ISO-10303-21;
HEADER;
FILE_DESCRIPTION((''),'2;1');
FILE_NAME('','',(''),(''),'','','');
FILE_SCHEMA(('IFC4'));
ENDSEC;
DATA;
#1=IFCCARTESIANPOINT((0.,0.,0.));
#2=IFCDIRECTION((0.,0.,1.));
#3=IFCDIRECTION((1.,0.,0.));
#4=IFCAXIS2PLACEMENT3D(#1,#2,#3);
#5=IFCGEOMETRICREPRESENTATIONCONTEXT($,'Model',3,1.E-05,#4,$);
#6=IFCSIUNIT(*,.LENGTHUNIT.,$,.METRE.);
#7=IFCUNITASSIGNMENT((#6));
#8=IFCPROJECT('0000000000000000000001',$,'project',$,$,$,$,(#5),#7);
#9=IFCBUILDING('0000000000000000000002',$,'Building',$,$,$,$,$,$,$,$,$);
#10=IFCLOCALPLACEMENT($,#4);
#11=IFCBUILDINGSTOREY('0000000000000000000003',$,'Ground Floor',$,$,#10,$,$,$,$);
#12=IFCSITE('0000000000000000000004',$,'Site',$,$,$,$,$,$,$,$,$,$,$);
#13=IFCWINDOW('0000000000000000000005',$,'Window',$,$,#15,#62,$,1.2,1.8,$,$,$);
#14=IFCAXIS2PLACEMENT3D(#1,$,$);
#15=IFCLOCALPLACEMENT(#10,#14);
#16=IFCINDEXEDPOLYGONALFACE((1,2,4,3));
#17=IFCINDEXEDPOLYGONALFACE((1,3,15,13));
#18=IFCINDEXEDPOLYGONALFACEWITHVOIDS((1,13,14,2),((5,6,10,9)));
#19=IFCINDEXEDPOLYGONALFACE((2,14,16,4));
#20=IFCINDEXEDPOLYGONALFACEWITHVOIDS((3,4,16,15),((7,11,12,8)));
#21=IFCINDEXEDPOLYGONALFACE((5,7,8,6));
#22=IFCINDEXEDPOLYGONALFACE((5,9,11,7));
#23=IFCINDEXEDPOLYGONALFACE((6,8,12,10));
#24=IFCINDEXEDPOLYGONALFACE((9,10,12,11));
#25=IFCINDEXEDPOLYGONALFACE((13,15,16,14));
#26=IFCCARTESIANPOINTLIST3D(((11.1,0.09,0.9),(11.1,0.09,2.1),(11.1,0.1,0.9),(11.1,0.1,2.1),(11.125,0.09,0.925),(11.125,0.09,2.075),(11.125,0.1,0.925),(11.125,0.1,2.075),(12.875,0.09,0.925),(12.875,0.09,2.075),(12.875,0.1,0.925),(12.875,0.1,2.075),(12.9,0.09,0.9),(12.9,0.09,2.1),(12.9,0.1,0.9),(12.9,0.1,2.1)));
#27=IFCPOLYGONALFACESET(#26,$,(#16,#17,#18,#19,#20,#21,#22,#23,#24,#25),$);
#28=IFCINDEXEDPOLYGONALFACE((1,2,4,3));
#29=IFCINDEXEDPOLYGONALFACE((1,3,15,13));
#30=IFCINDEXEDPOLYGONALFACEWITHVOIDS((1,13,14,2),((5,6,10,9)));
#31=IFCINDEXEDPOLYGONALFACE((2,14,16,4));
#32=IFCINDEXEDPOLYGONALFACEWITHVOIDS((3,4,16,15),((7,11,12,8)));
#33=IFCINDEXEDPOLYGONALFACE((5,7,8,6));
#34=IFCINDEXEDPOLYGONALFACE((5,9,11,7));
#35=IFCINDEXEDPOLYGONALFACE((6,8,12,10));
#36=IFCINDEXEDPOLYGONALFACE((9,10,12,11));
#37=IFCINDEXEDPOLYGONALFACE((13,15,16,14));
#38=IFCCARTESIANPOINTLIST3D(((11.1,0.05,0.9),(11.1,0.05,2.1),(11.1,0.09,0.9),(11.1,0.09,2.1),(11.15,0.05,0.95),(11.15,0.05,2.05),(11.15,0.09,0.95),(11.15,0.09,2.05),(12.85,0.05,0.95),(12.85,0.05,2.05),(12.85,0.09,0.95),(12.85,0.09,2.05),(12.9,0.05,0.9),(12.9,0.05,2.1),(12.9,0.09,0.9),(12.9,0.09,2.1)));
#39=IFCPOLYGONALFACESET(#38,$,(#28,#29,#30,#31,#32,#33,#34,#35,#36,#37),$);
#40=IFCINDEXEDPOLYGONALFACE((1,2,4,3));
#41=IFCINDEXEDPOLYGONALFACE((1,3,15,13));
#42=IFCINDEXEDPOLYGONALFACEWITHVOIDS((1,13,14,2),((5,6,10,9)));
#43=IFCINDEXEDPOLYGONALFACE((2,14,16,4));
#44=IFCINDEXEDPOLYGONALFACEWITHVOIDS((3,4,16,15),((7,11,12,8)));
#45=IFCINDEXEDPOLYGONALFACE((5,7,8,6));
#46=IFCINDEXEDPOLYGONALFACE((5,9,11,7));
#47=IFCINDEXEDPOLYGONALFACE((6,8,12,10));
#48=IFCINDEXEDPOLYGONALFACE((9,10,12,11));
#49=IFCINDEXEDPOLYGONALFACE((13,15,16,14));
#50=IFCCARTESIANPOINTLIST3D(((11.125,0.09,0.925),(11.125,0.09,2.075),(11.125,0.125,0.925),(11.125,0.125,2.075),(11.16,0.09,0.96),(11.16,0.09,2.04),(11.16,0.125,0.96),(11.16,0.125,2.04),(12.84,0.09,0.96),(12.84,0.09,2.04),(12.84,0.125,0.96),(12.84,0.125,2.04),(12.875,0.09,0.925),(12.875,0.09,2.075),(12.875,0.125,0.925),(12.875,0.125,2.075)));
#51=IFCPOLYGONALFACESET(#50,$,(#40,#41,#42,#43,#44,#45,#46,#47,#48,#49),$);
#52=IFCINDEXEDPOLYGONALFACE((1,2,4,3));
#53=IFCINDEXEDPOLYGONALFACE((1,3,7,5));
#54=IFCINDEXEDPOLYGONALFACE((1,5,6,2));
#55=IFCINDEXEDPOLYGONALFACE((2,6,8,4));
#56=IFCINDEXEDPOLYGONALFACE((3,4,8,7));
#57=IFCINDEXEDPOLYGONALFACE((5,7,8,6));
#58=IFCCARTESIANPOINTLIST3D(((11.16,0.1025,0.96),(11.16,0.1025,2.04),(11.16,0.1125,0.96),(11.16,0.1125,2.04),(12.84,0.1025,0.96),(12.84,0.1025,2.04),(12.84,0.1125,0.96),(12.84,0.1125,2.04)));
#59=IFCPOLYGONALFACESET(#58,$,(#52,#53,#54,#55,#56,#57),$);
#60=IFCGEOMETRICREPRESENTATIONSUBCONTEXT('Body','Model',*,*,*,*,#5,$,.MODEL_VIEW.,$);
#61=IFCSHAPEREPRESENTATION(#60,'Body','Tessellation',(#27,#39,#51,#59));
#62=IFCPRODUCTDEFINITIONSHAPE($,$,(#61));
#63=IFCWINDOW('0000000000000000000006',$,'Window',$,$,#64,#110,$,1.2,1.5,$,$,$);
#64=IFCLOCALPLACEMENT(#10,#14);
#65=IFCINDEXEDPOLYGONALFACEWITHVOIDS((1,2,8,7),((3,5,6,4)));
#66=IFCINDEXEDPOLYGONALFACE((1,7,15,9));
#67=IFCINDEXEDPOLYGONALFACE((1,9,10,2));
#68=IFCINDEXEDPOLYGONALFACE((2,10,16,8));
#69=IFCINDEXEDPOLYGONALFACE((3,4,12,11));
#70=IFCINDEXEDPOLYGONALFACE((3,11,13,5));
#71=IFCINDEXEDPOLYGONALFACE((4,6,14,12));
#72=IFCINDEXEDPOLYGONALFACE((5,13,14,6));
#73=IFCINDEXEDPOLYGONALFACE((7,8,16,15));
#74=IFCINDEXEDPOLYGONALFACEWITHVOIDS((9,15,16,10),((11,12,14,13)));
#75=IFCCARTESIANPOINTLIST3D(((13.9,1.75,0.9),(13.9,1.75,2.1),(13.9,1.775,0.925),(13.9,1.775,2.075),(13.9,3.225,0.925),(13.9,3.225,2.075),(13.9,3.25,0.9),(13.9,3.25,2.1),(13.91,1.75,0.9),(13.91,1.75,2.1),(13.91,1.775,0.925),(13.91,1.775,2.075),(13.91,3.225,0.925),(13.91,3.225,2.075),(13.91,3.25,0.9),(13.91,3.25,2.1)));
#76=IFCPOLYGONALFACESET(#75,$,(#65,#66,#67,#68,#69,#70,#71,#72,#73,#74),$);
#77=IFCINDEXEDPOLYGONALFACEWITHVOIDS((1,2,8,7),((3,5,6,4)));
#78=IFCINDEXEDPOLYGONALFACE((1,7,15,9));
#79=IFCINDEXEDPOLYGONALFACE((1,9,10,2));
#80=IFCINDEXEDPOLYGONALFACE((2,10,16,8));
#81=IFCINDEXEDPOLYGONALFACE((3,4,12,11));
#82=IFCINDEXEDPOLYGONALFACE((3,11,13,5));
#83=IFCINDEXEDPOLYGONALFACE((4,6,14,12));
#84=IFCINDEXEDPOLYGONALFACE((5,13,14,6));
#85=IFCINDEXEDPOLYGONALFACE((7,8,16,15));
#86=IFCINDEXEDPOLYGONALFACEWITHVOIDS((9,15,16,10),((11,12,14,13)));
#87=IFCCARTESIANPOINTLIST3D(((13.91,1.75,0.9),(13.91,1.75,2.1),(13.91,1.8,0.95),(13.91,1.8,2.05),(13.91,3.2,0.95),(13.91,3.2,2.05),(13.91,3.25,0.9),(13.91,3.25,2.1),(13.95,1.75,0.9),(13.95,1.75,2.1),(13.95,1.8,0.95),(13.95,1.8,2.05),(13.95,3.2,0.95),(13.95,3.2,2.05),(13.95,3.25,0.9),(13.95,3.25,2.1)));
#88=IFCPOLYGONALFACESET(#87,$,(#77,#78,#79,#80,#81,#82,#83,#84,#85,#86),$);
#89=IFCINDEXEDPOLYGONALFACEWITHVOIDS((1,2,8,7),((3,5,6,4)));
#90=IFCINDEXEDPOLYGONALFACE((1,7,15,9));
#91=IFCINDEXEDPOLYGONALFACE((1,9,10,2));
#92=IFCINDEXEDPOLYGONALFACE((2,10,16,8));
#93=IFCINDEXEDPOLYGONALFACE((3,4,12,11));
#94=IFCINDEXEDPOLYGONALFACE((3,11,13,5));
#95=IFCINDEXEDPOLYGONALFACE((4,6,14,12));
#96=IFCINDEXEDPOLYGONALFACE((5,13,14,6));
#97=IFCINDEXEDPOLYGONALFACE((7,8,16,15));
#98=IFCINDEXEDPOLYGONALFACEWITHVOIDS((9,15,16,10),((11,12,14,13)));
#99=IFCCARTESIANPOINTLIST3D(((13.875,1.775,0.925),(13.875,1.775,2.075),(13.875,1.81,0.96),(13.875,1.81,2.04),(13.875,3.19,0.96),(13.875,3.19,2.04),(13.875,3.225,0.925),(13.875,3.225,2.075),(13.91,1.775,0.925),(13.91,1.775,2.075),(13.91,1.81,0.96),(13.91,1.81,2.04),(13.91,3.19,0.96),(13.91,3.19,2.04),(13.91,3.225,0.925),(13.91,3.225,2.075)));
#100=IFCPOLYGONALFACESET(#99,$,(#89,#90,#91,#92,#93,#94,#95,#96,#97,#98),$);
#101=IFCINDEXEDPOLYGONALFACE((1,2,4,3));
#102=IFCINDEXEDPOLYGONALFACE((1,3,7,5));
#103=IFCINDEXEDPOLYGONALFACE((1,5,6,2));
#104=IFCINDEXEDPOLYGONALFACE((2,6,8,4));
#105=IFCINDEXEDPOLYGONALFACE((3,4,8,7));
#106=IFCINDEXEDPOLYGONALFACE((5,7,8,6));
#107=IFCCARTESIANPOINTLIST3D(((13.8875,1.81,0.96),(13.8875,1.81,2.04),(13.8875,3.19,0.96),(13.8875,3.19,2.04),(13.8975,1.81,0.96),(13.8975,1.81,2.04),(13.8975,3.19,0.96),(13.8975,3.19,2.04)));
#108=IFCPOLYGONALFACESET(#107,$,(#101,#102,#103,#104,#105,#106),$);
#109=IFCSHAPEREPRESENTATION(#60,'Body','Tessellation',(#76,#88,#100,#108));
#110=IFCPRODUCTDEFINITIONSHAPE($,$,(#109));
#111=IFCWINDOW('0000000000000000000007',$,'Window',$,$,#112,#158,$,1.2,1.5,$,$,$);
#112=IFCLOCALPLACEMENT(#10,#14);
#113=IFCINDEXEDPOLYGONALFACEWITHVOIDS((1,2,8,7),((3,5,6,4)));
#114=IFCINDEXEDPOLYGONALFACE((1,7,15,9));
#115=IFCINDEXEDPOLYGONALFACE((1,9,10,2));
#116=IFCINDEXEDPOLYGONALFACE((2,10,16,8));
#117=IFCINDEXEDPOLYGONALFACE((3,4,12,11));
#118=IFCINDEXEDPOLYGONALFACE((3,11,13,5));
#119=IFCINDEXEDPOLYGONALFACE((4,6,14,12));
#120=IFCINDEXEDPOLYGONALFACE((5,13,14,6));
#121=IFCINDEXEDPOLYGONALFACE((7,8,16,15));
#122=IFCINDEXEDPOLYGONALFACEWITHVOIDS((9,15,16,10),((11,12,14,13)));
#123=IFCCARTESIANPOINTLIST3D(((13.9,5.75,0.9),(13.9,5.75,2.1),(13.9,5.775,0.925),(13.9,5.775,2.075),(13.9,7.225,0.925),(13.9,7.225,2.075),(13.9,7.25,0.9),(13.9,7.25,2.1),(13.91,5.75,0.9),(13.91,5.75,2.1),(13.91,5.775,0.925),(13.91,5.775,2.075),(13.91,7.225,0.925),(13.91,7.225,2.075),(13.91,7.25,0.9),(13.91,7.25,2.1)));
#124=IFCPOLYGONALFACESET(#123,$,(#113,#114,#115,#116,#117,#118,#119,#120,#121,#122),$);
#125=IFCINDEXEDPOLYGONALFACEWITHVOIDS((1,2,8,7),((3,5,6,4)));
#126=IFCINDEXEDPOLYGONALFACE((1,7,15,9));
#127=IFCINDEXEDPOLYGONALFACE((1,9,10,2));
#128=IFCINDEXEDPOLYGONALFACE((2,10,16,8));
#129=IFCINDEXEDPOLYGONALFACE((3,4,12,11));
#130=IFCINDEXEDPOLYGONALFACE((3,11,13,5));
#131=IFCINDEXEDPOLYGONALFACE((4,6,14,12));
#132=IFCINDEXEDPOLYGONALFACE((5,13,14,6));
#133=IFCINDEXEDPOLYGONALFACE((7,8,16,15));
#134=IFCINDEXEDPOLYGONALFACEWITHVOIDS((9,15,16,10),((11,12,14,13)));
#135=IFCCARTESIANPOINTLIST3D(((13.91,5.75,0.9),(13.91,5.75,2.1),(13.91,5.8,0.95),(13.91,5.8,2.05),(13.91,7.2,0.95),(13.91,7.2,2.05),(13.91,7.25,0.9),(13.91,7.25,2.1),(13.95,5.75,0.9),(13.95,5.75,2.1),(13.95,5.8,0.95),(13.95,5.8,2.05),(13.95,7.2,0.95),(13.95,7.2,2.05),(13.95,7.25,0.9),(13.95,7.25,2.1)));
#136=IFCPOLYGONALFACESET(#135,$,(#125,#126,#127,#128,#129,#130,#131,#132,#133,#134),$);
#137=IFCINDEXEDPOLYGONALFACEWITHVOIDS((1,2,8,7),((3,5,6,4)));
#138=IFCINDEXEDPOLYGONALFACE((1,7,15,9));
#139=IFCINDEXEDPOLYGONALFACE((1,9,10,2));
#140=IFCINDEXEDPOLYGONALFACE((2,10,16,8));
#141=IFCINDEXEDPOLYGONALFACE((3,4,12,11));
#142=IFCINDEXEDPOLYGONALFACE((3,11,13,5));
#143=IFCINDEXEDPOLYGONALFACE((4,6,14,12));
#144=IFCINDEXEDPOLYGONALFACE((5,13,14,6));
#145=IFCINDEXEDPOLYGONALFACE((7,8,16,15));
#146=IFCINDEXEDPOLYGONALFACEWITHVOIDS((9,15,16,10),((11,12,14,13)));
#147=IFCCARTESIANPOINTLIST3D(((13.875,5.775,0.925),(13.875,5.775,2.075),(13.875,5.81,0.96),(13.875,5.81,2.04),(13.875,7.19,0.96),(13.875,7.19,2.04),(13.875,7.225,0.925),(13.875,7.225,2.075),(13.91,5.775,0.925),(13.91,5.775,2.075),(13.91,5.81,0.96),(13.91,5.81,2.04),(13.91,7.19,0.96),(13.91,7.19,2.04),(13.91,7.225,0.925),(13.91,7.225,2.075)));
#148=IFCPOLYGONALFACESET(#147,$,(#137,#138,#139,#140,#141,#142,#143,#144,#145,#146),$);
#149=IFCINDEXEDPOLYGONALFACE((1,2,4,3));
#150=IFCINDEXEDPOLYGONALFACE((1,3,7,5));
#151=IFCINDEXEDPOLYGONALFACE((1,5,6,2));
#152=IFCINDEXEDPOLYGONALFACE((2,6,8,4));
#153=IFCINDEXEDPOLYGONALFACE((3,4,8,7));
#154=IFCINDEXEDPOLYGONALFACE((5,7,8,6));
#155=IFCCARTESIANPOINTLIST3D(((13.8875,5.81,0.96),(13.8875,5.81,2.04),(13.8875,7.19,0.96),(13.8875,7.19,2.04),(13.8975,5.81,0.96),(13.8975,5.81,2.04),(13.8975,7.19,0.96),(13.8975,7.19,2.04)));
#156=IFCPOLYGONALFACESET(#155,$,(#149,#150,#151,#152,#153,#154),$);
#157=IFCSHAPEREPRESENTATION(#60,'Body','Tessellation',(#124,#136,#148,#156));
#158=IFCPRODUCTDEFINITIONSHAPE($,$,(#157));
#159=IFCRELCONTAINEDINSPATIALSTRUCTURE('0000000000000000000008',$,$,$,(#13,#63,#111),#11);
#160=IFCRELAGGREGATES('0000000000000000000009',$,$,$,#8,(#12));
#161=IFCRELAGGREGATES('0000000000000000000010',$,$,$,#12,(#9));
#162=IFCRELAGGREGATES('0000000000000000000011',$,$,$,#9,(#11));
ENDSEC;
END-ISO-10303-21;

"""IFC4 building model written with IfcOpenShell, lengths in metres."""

from ifc_helpers import new_model, si_unit, frame, origin_with_axes, place, context, subcontext, project, spatial, line, indexed_curve, outline, extrude, element, save


model = new_model("IFC4")

# Units and contexts
model_context = context("Model", 3, precision=1e-05, world=origin_with_axes())
body_context = subcontext(model_context, "Body", "Model", "MODEL_VIEW")
ifc_project = project(units=[si_unit("LENGTHUNIT", "METRE")], contexts=[model_context])

# Site, building, storey
site = spatial("IfcSite", under=ifc_project, Name="Site")
building = spatial("IfcBuilding", under=site, Name="Building")
storey_placement = place(None, origin_with_axes())
storey = spatial("IfcBuildingStorey", under=building, at=storey_placement, Name="Ground Floor")

# Windows
window_placement = place(storey_placement, frame((11.1, 0.0, 0.9), z_axis=(0.0, 0.0, 1.0), x_axis=(1.0, 0.0, 0.0)))
element("IfcWindow", 1, at=window_placement, inside=storey, Name="Window", OverallHeight=1.2, OverallWidth=1.8, context=body_context, shape_type="SweptSolid", body=[
    extrude(outline(indexed_curve([(0.0, 0.0), (1.8, 0.0), (1.8, 1.2), (0.0, 1.2)], segments=[line(1, 2, 3, 4, 1)]), holes=[indexed_curve([(0.025, 0.025), (1.775, 0.025), (1.775, 1.175), (0.025, 1.175)], segments=[line(1, 2, 3, 4, 1)])]), frame((0.0, 0.09, 0.0), z_axis=(0.0, -1.0, 0.0), x_axis=(1.0, 0.0, 0.0)), (0.0, 0.0, -1.0), 0.01),
    extrude(outline(indexed_curve([(0.0, 0.0), (1.8, 0.0), (1.8, 1.2), (0.0, 1.2)], segments=[line(1, 2, 3, 4, 1)]), holes=[indexed_curve([(0.05, 0.05), (1.75, 0.05), (1.75, 1.15), (0.05, 1.15)], segments=[line(1, 2, 3, 4, 1)])]), frame((0.0, 0.05, 0.0), z_axis=(0.0, -1.0, 0.0), x_axis=(1.0, 0.0, 0.0)), (0.0, 0.0, -1.0), 0.04),
    extrude(outline(indexed_curve([(0.0, 0.0), (1.75, 0.0), (1.75, 1.15), (0.0, 1.15)], segments=[line(1, 2, 3, 4, 1)]), holes=[indexed_curve([(0.035, 0.035), (1.715, 0.035), (1.715, 1.115), (0.035, 1.115)], segments=[line(1, 2, 3, 4, 1)])]), frame((0.025, 0.09, 0.025), z_axis=(0.0, -1.0, 0.0), x_axis=(1.0, 0.0, 0.0)), (0.0, 0.0, -1.0), 0.035),
    extrude(outline(indexed_curve([(0.035, 0.035), (1.715, 0.035), (1.715, 1.115), (0.035, 1.115)], segments=[line(1, 2, 3, 4, 1)])), frame((0.025, 0.1025, 0.025), z_axis=(0.0, -1.0, 0.0), x_axis=(1.0, 0.0, 0.0)), (0.0, 0.0, -1.0), 0.01),
])
for number, where, z_axis, x_axis, name in (
    (2, (14.0, 1.75, 0.9), (0.0, 0.0, 1.0), (0.0, 1.0, 0.0), "Window"),
    (3, (14.0, 5.75, 0.9), (0.0, 0.0, 1.0), (0.0, 1.0, 0.0), "Window"),
):
    element("IfcWindow", number, at=place(storey_placement, frame(where, z_axis=z_axis, x_axis=x_axis)), inside=storey, Name=name, OverallHeight=1.2, OverallWidth=1.5, context=body_context, shape_type="SweptSolid", body=[
        extrude(outline(indexed_curve([(0.0, 0.0), (1.5, 0.0), (1.5, 1.2), (0.0, 1.2)], segments=[line(1, 2, 3, 4, 1)]), holes=[indexed_curve([(0.025, 0.025), (1.475, 0.025), (1.475, 1.175), (0.025, 1.175)], segments=[line(1, 2, 3, 4, 1)])]), frame((0.0, 0.09, 0.0), z_axis=(0.0, -1.0, 0.0), x_axis=(1.0, 0.0, 0.0)), (0.0, 0.0, -1.0), 0.01),
        extrude(outline(indexed_curve([(0.0, 0.0), (1.5, 0.0), (1.5, 1.2), (0.0, 1.2)], segments=[line(1, 2, 3, 4, 1)]), holes=[indexed_curve([(0.05, 0.05), (1.45, 0.05), (1.45, 1.15), (0.05, 1.15)], segments=[line(1, 2, 3, 4, 1)])]), frame((0.0, 0.05, 0.0), z_axis=(0.0, -1.0, 0.0), x_axis=(1.0, 0.0, 0.0)), (0.0, 0.0, -1.0), 0.04),
        extrude(outline(indexed_curve([(0.0, 0.0), (1.45, 0.0), (1.45, 1.15), (0.0, 1.15)], segments=[line(1, 2, 3, 4, 1)]), holes=[indexed_curve([(0.035, 0.035), (1.415, 0.035), (1.415, 1.115), (0.035, 1.115)], segments=[line(1, 2, 3, 4, 1)])]), frame((0.025, 0.09, 0.025), z_axis=(0.0, -1.0, 0.0), x_axis=(1.0, 0.0, 0.0)), (0.0, 0.0, -1.0), 0.035),
        extrude(outline(indexed_curve([(0.035, 0.035), (1.415, 0.035), (1.415, 1.115), (0.035, 1.115)], segments=[line(1, 2, 3, 4, 1)])), frame((0.025, 0.1025, 0.025), z_axis=(0.0, -1.0, 0.0), x_axis=(1.0, 0.0, 0.0)), (0.0, 0.0, -1.0), 0.01),
    ])

save(model, "model.ifc")
